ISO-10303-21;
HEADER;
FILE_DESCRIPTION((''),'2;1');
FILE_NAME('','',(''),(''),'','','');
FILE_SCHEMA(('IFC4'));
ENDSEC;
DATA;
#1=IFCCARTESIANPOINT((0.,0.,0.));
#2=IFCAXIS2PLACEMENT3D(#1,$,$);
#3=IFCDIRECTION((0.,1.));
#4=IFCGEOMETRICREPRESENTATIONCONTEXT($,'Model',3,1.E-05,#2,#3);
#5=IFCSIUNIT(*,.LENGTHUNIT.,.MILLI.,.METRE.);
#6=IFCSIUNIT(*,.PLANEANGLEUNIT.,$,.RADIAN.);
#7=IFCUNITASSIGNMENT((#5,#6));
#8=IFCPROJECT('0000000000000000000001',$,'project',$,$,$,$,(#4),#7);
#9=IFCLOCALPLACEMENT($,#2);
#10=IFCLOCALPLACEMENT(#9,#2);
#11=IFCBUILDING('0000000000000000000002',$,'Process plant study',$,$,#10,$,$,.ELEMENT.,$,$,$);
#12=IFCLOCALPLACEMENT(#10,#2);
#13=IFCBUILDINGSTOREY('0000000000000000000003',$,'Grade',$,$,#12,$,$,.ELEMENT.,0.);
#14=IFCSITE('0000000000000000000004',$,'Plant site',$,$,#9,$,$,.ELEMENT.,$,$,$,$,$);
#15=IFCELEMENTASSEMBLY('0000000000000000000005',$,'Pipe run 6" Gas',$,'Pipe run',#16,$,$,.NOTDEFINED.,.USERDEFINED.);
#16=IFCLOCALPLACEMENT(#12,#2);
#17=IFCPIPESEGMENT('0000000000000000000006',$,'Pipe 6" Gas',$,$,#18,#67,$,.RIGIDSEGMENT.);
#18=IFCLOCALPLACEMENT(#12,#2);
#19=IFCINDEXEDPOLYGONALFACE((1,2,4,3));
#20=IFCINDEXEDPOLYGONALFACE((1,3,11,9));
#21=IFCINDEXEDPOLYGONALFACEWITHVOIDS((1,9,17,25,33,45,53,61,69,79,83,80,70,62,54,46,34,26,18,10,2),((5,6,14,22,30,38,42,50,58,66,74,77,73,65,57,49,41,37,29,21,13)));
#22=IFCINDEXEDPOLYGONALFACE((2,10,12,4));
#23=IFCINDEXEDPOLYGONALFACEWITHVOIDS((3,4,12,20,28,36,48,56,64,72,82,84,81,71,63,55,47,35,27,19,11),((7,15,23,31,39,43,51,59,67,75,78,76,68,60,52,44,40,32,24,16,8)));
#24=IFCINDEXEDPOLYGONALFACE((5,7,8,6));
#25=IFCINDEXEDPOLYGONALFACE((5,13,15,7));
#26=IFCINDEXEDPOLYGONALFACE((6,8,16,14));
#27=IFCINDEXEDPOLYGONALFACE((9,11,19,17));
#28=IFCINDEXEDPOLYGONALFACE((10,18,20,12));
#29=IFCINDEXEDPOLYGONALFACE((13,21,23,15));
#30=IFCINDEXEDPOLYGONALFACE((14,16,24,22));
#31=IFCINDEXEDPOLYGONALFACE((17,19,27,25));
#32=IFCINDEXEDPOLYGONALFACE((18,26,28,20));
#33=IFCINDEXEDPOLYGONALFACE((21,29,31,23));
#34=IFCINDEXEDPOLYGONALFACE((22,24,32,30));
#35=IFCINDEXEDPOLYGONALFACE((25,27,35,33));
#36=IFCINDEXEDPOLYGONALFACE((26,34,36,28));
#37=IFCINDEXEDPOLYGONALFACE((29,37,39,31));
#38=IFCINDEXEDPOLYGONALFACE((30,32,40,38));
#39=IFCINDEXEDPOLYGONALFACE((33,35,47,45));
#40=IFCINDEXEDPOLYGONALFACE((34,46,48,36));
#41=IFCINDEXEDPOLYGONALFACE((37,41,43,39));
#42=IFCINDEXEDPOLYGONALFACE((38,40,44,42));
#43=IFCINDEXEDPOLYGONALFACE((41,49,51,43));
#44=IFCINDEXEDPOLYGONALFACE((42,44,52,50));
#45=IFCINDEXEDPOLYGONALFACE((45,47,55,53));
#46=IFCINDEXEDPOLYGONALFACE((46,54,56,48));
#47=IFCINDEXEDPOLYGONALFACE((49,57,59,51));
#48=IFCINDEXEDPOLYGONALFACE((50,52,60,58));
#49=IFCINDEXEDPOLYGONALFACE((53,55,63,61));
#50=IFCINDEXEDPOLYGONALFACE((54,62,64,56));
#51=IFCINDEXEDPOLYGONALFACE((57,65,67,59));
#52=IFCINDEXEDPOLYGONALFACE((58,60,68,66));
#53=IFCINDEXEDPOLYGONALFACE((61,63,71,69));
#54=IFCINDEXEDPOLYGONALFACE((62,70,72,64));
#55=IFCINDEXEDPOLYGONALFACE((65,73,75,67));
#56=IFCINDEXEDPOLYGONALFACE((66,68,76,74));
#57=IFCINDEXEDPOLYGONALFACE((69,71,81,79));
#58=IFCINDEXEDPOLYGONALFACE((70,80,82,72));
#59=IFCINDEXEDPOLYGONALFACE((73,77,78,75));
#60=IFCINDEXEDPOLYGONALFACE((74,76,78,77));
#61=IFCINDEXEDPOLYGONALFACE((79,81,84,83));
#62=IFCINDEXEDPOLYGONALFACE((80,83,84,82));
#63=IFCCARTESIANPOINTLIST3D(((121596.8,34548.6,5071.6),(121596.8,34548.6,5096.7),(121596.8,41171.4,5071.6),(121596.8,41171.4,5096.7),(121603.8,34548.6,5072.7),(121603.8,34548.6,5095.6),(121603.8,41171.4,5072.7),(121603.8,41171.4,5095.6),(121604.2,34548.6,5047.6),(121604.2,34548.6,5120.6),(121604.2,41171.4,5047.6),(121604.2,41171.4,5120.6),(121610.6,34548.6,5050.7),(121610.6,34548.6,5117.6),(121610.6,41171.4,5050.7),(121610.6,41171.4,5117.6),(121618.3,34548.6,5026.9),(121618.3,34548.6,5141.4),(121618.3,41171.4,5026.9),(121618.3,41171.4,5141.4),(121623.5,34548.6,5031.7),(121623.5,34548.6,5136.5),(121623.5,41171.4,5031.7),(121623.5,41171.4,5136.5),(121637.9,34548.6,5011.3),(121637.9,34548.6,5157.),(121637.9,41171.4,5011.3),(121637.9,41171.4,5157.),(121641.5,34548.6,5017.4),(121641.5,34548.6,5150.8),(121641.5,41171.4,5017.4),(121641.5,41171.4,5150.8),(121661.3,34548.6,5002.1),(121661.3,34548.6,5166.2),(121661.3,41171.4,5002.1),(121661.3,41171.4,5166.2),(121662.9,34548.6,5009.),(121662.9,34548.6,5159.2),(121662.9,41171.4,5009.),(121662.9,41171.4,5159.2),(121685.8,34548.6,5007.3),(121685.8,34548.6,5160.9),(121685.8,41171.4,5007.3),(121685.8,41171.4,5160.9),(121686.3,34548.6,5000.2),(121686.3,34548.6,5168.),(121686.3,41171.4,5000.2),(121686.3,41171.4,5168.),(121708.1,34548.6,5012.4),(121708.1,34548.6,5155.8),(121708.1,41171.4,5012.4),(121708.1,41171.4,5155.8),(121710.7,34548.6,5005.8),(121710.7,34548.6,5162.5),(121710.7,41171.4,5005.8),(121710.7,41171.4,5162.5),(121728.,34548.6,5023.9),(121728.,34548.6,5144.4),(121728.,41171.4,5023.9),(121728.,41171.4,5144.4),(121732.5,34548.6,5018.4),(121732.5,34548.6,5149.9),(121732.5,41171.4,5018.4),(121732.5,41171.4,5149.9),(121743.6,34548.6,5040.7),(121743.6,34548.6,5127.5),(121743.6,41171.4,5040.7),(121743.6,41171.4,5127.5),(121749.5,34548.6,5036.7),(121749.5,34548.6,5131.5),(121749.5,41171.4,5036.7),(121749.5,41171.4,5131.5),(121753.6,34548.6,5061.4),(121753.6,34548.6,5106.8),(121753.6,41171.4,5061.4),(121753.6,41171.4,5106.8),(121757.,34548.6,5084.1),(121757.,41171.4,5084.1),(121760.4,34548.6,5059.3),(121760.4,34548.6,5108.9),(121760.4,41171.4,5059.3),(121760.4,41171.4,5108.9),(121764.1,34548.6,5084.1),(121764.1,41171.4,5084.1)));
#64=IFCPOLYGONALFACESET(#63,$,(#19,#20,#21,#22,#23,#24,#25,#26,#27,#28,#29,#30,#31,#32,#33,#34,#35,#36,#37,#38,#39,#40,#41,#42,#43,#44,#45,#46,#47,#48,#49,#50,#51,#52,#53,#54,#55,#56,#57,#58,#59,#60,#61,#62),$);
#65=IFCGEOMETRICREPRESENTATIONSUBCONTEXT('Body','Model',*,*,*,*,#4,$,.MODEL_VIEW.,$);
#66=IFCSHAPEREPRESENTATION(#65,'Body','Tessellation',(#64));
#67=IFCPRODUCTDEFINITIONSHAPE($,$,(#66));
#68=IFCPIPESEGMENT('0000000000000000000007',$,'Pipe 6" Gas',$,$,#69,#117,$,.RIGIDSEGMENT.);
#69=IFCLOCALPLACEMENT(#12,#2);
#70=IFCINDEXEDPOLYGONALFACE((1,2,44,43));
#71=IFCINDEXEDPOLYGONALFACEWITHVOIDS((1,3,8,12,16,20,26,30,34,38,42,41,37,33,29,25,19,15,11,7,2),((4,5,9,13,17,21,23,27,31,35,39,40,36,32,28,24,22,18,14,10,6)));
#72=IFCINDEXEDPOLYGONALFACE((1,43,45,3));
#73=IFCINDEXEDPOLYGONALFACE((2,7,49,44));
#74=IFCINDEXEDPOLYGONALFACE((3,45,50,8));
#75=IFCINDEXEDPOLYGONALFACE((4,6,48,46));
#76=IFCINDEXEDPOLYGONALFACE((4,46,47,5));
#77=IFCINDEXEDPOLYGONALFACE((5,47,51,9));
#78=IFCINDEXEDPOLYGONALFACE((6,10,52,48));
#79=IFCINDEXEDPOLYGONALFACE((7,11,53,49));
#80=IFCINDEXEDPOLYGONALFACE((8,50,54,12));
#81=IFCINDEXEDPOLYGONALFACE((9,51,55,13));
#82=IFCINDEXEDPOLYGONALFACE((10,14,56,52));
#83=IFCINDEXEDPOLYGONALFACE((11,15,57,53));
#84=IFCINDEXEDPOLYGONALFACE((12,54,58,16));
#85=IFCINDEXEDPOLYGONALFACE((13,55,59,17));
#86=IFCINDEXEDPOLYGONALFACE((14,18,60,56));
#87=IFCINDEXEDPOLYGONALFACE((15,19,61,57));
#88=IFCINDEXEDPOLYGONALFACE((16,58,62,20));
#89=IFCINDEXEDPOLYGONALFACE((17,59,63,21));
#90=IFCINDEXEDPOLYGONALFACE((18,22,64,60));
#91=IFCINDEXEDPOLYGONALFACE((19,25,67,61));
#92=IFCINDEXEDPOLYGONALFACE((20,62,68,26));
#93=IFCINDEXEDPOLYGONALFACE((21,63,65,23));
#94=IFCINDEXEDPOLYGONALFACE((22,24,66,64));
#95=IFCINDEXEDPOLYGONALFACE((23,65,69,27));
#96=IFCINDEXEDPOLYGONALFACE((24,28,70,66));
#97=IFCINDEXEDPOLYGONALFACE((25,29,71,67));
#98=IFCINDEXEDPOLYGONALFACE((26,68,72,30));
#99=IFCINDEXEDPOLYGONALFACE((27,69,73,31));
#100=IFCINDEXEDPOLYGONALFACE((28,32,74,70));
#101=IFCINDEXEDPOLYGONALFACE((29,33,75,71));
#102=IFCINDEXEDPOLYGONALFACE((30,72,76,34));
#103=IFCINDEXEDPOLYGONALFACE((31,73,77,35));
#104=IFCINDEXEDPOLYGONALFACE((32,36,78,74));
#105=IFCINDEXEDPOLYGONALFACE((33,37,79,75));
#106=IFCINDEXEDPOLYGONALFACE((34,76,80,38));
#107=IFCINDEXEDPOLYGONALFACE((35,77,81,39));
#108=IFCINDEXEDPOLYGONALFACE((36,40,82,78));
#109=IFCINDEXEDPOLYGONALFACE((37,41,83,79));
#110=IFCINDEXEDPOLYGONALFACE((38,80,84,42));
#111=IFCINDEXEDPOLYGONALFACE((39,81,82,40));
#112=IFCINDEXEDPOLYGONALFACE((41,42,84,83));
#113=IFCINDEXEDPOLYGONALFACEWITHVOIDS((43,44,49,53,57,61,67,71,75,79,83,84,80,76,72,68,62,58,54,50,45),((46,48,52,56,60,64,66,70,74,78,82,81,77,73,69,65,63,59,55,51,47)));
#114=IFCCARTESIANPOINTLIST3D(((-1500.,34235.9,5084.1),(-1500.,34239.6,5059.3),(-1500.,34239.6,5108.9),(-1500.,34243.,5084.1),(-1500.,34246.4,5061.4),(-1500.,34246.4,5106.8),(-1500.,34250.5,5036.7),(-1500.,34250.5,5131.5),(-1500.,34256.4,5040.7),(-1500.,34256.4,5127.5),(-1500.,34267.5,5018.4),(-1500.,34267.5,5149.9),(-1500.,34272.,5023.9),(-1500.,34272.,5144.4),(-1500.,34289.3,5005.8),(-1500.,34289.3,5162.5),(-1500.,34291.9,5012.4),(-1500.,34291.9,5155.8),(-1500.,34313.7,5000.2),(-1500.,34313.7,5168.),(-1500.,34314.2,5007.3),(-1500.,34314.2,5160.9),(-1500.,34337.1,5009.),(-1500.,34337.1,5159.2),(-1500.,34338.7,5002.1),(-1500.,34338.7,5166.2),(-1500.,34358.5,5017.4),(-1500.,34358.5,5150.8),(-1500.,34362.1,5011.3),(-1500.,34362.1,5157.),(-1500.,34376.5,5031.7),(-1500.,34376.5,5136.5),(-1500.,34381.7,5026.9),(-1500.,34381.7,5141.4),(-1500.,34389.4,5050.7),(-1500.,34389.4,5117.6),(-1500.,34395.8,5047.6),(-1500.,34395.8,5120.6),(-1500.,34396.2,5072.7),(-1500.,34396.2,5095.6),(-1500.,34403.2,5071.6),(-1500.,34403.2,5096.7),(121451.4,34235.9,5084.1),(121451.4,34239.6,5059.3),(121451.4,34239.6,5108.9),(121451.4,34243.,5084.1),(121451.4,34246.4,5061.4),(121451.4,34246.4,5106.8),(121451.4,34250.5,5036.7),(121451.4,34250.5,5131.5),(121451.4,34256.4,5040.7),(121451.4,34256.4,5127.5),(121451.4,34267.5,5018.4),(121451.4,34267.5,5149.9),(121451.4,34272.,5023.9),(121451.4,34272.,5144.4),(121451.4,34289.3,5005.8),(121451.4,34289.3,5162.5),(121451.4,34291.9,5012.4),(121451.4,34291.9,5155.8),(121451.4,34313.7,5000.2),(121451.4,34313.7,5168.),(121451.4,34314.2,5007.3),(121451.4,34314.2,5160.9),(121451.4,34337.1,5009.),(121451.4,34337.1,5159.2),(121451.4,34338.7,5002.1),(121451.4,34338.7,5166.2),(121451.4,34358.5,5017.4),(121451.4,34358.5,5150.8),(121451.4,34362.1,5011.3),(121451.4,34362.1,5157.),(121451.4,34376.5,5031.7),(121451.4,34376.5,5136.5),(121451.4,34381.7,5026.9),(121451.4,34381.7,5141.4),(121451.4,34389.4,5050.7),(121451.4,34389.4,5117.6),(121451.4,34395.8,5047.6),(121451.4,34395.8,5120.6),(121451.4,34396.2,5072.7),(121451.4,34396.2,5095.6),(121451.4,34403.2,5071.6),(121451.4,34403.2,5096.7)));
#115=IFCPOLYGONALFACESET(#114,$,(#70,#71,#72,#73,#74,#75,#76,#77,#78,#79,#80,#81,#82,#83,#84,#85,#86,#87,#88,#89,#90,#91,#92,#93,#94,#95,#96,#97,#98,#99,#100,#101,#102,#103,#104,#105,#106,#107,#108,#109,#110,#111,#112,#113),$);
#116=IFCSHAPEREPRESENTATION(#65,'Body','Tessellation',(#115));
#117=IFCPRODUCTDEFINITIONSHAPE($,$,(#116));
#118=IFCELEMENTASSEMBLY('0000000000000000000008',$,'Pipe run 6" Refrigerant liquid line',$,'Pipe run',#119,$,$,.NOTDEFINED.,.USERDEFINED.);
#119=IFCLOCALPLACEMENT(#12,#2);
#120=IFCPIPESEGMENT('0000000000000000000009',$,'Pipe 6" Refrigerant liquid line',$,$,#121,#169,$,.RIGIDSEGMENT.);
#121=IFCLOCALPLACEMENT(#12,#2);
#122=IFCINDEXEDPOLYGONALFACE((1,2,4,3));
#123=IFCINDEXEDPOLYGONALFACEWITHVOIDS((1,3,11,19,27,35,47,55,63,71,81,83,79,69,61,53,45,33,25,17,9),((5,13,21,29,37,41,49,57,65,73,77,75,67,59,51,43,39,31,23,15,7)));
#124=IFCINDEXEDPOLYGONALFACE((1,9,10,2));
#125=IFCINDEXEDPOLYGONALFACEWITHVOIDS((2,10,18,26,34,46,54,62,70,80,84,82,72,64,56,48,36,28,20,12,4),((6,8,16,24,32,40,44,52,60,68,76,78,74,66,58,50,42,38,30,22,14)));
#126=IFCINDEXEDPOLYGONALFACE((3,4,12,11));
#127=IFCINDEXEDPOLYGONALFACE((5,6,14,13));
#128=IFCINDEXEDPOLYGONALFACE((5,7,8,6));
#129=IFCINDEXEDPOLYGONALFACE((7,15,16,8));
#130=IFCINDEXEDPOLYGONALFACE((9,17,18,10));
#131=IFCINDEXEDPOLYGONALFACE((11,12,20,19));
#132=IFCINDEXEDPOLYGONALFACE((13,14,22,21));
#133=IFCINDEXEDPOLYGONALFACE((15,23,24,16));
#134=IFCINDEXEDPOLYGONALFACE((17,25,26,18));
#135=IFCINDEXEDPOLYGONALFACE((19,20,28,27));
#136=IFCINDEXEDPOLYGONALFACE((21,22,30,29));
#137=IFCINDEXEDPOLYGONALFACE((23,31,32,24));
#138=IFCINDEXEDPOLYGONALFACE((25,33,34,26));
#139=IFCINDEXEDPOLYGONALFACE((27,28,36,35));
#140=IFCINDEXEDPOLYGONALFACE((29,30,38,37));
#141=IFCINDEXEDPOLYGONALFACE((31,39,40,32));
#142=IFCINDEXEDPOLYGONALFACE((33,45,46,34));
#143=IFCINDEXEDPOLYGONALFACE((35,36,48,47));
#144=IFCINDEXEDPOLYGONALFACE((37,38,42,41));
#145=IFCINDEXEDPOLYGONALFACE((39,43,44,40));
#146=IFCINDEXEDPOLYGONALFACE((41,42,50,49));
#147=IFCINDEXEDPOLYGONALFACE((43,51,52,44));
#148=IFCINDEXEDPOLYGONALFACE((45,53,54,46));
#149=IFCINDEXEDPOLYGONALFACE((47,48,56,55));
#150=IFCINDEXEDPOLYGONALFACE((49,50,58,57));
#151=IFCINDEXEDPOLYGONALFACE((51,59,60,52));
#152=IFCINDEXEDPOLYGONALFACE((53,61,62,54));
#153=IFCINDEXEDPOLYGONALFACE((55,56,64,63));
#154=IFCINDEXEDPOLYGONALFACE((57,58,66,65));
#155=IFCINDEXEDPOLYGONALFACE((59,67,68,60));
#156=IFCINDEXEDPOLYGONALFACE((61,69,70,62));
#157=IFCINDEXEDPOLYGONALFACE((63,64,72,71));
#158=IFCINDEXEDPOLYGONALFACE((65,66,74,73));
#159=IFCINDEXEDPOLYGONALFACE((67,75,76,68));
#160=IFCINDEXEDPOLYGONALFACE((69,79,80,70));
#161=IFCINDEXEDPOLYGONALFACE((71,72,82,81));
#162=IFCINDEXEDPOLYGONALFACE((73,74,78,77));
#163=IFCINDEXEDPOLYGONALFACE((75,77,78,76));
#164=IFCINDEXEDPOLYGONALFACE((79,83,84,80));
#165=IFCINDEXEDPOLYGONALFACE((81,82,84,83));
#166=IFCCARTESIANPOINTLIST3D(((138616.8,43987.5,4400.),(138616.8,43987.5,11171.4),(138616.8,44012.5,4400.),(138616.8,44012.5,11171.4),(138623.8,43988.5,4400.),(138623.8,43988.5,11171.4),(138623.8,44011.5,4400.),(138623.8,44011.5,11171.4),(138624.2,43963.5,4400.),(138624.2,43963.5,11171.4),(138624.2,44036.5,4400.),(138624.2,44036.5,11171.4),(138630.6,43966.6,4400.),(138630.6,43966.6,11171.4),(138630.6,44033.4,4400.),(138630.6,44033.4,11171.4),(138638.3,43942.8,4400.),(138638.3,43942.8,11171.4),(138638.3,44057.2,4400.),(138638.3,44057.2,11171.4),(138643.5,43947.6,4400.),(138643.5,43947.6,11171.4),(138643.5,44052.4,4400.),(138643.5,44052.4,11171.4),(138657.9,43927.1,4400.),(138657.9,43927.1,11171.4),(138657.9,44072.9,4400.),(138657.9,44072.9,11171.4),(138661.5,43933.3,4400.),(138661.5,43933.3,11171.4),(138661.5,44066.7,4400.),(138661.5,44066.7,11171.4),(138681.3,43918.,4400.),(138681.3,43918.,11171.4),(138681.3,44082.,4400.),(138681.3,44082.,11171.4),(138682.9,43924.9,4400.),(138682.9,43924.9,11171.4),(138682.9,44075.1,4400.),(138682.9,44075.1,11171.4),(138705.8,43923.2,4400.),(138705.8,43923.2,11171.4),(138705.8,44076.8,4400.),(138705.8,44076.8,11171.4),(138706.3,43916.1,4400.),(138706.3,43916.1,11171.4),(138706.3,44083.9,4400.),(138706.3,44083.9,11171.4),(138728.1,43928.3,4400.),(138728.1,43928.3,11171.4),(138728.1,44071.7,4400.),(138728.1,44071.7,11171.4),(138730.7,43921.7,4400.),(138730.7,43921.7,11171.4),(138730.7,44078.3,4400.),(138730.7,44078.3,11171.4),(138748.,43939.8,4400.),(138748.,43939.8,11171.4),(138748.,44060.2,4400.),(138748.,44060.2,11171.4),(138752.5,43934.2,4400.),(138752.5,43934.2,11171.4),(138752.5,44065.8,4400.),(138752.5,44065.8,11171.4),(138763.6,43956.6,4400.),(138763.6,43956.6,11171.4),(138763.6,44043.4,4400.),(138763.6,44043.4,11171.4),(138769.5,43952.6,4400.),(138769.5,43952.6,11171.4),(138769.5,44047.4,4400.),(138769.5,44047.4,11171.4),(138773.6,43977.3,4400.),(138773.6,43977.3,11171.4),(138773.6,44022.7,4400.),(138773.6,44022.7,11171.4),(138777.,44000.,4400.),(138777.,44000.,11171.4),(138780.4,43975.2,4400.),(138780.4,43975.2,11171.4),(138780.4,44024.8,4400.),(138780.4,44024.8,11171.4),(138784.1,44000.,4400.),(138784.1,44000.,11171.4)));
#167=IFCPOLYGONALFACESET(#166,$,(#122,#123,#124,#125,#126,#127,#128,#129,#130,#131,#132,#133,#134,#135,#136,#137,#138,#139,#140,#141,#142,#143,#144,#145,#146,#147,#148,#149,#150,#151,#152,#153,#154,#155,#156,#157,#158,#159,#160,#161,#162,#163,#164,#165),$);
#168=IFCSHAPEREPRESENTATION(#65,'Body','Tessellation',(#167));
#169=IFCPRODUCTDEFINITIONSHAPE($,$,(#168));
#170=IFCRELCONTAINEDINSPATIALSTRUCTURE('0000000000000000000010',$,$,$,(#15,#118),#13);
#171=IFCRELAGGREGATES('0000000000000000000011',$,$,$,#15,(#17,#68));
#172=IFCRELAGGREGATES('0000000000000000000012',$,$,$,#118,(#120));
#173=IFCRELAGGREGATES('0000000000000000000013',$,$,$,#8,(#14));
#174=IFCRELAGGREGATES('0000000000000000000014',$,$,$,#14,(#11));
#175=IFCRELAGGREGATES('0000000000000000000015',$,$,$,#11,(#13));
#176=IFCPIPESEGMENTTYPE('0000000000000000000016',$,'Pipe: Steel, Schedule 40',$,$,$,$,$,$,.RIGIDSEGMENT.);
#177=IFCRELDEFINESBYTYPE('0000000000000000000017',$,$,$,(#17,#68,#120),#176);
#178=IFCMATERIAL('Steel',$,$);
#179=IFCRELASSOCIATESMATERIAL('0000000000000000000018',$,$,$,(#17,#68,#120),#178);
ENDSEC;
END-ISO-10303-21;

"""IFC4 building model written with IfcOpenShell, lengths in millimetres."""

from ifc_helpers import new_model, si_unit, direction, frame, origin, origin_with_axes, origin_2d, place, context, subcontext, project, spatial, hollow_circle, extrude, material, type_object, element, aggregate, save


model = new_model("IFC4")

# Units and contexts
model_context = context("Model", 3, precision=1e-05, world=origin(), true_north=direction((0.0, 1.0)))
body_context = subcontext(model_context, "Body", "Model", "MODEL_VIEW")
ifc_project = project(units=[si_unit("LENGTHUNIT", "METRE", prefix="MILLI"), si_unit("PLANEANGLEUNIT", "RADIAN")], contexts=[model_context])

# Site, building, storey
site_placement = place(None, origin())
site = spatial("IfcSite", under=ifc_project, at=site_placement, Name="Plant site", CompositionType="ELEMENT")
building_placement = place(site_placement, origin())
building = spatial("IfcBuilding", under=site, at=building_placement, Name="Process plant study", CompositionType="ELEMENT")
storey_placement = place(building_placement, origin())
storey = spatial("IfcBuildingStorey", under=building, at=storey_placement, Name="Grade", CompositionType="ELEMENT", Elevation=0.0)

# Shared definitions
ifc_material = material(Name="Steel")
pipe_segment_type = type_object("IfcPipeSegmentType", Name="Pipe: Steel, Schedule 40", PredefinedType="RIGIDSEGMENT")

# Element assemblies, pipe segments
assembly_1_placement = place(storey_placement, origin_with_axes())
assembly_1 = element("IfcElementAssembly", 1, at=assembly_1_placement, inside=storey, Name="Pipe run 6\" Gas", ObjectType="Pipe run", AssemblyPlace="NOTDEFINED", PredefinedType="USERDEFINED")
pipe_segment_1_placement = place(storey_placement, origin_with_axes())
pipe_segment_1 = element("IfcPipeSegment", 2, at=pipe_segment_1_placement, type_object=pipe_segment_type, material=ifc_material, Name="Pipe 6\" Gas", PredefinedType="RIGIDSEGMENT", context=body_context, shape_type="SweptSolid", body=[
    extrude(hollow_circle(Radius=84.1, WallThickness=7.1, at=origin_2d()), frame((121680.0, 41171.4, 5084.1), z_axis=(0.0, -1.0, 0.0), x_axis=(1.0, 0.0, 0.0)), (0.0, 0.0, 1.0), 6622.8),
])
pipe_segment_2_placement = place(storey_placement, origin_with_axes())
pipe_segment_2 = element("IfcPipeSegment", 3, at=pipe_segment_2_placement, type_object=pipe_segment_type, material=ifc_material, Name="Pipe 6\" Gas", PredefinedType="RIGIDSEGMENT", context=body_context, shape_type="SweptSolid", body=[
    extrude(hollow_circle(Radius=84.1, WallThickness=7.1, at=origin_2d()), frame((121451.4, 34320.0, 5084.1), z_axis=(-1.0, 0.0, 0.0), x_axis=(0.0, -1.0, 0.0)), (0.0, 0.0, 1.0), 122951.4),
])
assembly_2_placement = place(storey_placement, origin_with_axes())
assembly_2 = element("IfcElementAssembly", 4, at=assembly_2_placement, inside=storey, Name="Pipe run 6\" Refrigerant liquid line", ObjectType="Pipe run", AssemblyPlace="NOTDEFINED", PredefinedType="USERDEFINED")
pipe_segment_3_placement = place(storey_placement, origin_with_axes())
pipe_segment_3 = element("IfcPipeSegment", 5, at=pipe_segment_3_placement, type_object=pipe_segment_type, material=ifc_material, Name="Pipe 6\" Refrigerant liquid line", PredefinedType="RIGIDSEGMENT", context=body_context, shape_type="SweptSolid", body=[
    extrude(hollow_circle(Radius=84.1, WallThickness=7.1, at=origin_2d()), frame((138700.0, 44000.0, 4400.0), z_axis=(0.0, 0.0, 1.0), x_axis=(1.0, 0.0, 0.0)), (0.0, 0.0, 1.0), 6771.4),
])

aggregate(assembly_1, [pipe_segment_1, pipe_segment_2])
aggregate(assembly_2, [pipe_segment_3])

save(model, "model.ifc")
